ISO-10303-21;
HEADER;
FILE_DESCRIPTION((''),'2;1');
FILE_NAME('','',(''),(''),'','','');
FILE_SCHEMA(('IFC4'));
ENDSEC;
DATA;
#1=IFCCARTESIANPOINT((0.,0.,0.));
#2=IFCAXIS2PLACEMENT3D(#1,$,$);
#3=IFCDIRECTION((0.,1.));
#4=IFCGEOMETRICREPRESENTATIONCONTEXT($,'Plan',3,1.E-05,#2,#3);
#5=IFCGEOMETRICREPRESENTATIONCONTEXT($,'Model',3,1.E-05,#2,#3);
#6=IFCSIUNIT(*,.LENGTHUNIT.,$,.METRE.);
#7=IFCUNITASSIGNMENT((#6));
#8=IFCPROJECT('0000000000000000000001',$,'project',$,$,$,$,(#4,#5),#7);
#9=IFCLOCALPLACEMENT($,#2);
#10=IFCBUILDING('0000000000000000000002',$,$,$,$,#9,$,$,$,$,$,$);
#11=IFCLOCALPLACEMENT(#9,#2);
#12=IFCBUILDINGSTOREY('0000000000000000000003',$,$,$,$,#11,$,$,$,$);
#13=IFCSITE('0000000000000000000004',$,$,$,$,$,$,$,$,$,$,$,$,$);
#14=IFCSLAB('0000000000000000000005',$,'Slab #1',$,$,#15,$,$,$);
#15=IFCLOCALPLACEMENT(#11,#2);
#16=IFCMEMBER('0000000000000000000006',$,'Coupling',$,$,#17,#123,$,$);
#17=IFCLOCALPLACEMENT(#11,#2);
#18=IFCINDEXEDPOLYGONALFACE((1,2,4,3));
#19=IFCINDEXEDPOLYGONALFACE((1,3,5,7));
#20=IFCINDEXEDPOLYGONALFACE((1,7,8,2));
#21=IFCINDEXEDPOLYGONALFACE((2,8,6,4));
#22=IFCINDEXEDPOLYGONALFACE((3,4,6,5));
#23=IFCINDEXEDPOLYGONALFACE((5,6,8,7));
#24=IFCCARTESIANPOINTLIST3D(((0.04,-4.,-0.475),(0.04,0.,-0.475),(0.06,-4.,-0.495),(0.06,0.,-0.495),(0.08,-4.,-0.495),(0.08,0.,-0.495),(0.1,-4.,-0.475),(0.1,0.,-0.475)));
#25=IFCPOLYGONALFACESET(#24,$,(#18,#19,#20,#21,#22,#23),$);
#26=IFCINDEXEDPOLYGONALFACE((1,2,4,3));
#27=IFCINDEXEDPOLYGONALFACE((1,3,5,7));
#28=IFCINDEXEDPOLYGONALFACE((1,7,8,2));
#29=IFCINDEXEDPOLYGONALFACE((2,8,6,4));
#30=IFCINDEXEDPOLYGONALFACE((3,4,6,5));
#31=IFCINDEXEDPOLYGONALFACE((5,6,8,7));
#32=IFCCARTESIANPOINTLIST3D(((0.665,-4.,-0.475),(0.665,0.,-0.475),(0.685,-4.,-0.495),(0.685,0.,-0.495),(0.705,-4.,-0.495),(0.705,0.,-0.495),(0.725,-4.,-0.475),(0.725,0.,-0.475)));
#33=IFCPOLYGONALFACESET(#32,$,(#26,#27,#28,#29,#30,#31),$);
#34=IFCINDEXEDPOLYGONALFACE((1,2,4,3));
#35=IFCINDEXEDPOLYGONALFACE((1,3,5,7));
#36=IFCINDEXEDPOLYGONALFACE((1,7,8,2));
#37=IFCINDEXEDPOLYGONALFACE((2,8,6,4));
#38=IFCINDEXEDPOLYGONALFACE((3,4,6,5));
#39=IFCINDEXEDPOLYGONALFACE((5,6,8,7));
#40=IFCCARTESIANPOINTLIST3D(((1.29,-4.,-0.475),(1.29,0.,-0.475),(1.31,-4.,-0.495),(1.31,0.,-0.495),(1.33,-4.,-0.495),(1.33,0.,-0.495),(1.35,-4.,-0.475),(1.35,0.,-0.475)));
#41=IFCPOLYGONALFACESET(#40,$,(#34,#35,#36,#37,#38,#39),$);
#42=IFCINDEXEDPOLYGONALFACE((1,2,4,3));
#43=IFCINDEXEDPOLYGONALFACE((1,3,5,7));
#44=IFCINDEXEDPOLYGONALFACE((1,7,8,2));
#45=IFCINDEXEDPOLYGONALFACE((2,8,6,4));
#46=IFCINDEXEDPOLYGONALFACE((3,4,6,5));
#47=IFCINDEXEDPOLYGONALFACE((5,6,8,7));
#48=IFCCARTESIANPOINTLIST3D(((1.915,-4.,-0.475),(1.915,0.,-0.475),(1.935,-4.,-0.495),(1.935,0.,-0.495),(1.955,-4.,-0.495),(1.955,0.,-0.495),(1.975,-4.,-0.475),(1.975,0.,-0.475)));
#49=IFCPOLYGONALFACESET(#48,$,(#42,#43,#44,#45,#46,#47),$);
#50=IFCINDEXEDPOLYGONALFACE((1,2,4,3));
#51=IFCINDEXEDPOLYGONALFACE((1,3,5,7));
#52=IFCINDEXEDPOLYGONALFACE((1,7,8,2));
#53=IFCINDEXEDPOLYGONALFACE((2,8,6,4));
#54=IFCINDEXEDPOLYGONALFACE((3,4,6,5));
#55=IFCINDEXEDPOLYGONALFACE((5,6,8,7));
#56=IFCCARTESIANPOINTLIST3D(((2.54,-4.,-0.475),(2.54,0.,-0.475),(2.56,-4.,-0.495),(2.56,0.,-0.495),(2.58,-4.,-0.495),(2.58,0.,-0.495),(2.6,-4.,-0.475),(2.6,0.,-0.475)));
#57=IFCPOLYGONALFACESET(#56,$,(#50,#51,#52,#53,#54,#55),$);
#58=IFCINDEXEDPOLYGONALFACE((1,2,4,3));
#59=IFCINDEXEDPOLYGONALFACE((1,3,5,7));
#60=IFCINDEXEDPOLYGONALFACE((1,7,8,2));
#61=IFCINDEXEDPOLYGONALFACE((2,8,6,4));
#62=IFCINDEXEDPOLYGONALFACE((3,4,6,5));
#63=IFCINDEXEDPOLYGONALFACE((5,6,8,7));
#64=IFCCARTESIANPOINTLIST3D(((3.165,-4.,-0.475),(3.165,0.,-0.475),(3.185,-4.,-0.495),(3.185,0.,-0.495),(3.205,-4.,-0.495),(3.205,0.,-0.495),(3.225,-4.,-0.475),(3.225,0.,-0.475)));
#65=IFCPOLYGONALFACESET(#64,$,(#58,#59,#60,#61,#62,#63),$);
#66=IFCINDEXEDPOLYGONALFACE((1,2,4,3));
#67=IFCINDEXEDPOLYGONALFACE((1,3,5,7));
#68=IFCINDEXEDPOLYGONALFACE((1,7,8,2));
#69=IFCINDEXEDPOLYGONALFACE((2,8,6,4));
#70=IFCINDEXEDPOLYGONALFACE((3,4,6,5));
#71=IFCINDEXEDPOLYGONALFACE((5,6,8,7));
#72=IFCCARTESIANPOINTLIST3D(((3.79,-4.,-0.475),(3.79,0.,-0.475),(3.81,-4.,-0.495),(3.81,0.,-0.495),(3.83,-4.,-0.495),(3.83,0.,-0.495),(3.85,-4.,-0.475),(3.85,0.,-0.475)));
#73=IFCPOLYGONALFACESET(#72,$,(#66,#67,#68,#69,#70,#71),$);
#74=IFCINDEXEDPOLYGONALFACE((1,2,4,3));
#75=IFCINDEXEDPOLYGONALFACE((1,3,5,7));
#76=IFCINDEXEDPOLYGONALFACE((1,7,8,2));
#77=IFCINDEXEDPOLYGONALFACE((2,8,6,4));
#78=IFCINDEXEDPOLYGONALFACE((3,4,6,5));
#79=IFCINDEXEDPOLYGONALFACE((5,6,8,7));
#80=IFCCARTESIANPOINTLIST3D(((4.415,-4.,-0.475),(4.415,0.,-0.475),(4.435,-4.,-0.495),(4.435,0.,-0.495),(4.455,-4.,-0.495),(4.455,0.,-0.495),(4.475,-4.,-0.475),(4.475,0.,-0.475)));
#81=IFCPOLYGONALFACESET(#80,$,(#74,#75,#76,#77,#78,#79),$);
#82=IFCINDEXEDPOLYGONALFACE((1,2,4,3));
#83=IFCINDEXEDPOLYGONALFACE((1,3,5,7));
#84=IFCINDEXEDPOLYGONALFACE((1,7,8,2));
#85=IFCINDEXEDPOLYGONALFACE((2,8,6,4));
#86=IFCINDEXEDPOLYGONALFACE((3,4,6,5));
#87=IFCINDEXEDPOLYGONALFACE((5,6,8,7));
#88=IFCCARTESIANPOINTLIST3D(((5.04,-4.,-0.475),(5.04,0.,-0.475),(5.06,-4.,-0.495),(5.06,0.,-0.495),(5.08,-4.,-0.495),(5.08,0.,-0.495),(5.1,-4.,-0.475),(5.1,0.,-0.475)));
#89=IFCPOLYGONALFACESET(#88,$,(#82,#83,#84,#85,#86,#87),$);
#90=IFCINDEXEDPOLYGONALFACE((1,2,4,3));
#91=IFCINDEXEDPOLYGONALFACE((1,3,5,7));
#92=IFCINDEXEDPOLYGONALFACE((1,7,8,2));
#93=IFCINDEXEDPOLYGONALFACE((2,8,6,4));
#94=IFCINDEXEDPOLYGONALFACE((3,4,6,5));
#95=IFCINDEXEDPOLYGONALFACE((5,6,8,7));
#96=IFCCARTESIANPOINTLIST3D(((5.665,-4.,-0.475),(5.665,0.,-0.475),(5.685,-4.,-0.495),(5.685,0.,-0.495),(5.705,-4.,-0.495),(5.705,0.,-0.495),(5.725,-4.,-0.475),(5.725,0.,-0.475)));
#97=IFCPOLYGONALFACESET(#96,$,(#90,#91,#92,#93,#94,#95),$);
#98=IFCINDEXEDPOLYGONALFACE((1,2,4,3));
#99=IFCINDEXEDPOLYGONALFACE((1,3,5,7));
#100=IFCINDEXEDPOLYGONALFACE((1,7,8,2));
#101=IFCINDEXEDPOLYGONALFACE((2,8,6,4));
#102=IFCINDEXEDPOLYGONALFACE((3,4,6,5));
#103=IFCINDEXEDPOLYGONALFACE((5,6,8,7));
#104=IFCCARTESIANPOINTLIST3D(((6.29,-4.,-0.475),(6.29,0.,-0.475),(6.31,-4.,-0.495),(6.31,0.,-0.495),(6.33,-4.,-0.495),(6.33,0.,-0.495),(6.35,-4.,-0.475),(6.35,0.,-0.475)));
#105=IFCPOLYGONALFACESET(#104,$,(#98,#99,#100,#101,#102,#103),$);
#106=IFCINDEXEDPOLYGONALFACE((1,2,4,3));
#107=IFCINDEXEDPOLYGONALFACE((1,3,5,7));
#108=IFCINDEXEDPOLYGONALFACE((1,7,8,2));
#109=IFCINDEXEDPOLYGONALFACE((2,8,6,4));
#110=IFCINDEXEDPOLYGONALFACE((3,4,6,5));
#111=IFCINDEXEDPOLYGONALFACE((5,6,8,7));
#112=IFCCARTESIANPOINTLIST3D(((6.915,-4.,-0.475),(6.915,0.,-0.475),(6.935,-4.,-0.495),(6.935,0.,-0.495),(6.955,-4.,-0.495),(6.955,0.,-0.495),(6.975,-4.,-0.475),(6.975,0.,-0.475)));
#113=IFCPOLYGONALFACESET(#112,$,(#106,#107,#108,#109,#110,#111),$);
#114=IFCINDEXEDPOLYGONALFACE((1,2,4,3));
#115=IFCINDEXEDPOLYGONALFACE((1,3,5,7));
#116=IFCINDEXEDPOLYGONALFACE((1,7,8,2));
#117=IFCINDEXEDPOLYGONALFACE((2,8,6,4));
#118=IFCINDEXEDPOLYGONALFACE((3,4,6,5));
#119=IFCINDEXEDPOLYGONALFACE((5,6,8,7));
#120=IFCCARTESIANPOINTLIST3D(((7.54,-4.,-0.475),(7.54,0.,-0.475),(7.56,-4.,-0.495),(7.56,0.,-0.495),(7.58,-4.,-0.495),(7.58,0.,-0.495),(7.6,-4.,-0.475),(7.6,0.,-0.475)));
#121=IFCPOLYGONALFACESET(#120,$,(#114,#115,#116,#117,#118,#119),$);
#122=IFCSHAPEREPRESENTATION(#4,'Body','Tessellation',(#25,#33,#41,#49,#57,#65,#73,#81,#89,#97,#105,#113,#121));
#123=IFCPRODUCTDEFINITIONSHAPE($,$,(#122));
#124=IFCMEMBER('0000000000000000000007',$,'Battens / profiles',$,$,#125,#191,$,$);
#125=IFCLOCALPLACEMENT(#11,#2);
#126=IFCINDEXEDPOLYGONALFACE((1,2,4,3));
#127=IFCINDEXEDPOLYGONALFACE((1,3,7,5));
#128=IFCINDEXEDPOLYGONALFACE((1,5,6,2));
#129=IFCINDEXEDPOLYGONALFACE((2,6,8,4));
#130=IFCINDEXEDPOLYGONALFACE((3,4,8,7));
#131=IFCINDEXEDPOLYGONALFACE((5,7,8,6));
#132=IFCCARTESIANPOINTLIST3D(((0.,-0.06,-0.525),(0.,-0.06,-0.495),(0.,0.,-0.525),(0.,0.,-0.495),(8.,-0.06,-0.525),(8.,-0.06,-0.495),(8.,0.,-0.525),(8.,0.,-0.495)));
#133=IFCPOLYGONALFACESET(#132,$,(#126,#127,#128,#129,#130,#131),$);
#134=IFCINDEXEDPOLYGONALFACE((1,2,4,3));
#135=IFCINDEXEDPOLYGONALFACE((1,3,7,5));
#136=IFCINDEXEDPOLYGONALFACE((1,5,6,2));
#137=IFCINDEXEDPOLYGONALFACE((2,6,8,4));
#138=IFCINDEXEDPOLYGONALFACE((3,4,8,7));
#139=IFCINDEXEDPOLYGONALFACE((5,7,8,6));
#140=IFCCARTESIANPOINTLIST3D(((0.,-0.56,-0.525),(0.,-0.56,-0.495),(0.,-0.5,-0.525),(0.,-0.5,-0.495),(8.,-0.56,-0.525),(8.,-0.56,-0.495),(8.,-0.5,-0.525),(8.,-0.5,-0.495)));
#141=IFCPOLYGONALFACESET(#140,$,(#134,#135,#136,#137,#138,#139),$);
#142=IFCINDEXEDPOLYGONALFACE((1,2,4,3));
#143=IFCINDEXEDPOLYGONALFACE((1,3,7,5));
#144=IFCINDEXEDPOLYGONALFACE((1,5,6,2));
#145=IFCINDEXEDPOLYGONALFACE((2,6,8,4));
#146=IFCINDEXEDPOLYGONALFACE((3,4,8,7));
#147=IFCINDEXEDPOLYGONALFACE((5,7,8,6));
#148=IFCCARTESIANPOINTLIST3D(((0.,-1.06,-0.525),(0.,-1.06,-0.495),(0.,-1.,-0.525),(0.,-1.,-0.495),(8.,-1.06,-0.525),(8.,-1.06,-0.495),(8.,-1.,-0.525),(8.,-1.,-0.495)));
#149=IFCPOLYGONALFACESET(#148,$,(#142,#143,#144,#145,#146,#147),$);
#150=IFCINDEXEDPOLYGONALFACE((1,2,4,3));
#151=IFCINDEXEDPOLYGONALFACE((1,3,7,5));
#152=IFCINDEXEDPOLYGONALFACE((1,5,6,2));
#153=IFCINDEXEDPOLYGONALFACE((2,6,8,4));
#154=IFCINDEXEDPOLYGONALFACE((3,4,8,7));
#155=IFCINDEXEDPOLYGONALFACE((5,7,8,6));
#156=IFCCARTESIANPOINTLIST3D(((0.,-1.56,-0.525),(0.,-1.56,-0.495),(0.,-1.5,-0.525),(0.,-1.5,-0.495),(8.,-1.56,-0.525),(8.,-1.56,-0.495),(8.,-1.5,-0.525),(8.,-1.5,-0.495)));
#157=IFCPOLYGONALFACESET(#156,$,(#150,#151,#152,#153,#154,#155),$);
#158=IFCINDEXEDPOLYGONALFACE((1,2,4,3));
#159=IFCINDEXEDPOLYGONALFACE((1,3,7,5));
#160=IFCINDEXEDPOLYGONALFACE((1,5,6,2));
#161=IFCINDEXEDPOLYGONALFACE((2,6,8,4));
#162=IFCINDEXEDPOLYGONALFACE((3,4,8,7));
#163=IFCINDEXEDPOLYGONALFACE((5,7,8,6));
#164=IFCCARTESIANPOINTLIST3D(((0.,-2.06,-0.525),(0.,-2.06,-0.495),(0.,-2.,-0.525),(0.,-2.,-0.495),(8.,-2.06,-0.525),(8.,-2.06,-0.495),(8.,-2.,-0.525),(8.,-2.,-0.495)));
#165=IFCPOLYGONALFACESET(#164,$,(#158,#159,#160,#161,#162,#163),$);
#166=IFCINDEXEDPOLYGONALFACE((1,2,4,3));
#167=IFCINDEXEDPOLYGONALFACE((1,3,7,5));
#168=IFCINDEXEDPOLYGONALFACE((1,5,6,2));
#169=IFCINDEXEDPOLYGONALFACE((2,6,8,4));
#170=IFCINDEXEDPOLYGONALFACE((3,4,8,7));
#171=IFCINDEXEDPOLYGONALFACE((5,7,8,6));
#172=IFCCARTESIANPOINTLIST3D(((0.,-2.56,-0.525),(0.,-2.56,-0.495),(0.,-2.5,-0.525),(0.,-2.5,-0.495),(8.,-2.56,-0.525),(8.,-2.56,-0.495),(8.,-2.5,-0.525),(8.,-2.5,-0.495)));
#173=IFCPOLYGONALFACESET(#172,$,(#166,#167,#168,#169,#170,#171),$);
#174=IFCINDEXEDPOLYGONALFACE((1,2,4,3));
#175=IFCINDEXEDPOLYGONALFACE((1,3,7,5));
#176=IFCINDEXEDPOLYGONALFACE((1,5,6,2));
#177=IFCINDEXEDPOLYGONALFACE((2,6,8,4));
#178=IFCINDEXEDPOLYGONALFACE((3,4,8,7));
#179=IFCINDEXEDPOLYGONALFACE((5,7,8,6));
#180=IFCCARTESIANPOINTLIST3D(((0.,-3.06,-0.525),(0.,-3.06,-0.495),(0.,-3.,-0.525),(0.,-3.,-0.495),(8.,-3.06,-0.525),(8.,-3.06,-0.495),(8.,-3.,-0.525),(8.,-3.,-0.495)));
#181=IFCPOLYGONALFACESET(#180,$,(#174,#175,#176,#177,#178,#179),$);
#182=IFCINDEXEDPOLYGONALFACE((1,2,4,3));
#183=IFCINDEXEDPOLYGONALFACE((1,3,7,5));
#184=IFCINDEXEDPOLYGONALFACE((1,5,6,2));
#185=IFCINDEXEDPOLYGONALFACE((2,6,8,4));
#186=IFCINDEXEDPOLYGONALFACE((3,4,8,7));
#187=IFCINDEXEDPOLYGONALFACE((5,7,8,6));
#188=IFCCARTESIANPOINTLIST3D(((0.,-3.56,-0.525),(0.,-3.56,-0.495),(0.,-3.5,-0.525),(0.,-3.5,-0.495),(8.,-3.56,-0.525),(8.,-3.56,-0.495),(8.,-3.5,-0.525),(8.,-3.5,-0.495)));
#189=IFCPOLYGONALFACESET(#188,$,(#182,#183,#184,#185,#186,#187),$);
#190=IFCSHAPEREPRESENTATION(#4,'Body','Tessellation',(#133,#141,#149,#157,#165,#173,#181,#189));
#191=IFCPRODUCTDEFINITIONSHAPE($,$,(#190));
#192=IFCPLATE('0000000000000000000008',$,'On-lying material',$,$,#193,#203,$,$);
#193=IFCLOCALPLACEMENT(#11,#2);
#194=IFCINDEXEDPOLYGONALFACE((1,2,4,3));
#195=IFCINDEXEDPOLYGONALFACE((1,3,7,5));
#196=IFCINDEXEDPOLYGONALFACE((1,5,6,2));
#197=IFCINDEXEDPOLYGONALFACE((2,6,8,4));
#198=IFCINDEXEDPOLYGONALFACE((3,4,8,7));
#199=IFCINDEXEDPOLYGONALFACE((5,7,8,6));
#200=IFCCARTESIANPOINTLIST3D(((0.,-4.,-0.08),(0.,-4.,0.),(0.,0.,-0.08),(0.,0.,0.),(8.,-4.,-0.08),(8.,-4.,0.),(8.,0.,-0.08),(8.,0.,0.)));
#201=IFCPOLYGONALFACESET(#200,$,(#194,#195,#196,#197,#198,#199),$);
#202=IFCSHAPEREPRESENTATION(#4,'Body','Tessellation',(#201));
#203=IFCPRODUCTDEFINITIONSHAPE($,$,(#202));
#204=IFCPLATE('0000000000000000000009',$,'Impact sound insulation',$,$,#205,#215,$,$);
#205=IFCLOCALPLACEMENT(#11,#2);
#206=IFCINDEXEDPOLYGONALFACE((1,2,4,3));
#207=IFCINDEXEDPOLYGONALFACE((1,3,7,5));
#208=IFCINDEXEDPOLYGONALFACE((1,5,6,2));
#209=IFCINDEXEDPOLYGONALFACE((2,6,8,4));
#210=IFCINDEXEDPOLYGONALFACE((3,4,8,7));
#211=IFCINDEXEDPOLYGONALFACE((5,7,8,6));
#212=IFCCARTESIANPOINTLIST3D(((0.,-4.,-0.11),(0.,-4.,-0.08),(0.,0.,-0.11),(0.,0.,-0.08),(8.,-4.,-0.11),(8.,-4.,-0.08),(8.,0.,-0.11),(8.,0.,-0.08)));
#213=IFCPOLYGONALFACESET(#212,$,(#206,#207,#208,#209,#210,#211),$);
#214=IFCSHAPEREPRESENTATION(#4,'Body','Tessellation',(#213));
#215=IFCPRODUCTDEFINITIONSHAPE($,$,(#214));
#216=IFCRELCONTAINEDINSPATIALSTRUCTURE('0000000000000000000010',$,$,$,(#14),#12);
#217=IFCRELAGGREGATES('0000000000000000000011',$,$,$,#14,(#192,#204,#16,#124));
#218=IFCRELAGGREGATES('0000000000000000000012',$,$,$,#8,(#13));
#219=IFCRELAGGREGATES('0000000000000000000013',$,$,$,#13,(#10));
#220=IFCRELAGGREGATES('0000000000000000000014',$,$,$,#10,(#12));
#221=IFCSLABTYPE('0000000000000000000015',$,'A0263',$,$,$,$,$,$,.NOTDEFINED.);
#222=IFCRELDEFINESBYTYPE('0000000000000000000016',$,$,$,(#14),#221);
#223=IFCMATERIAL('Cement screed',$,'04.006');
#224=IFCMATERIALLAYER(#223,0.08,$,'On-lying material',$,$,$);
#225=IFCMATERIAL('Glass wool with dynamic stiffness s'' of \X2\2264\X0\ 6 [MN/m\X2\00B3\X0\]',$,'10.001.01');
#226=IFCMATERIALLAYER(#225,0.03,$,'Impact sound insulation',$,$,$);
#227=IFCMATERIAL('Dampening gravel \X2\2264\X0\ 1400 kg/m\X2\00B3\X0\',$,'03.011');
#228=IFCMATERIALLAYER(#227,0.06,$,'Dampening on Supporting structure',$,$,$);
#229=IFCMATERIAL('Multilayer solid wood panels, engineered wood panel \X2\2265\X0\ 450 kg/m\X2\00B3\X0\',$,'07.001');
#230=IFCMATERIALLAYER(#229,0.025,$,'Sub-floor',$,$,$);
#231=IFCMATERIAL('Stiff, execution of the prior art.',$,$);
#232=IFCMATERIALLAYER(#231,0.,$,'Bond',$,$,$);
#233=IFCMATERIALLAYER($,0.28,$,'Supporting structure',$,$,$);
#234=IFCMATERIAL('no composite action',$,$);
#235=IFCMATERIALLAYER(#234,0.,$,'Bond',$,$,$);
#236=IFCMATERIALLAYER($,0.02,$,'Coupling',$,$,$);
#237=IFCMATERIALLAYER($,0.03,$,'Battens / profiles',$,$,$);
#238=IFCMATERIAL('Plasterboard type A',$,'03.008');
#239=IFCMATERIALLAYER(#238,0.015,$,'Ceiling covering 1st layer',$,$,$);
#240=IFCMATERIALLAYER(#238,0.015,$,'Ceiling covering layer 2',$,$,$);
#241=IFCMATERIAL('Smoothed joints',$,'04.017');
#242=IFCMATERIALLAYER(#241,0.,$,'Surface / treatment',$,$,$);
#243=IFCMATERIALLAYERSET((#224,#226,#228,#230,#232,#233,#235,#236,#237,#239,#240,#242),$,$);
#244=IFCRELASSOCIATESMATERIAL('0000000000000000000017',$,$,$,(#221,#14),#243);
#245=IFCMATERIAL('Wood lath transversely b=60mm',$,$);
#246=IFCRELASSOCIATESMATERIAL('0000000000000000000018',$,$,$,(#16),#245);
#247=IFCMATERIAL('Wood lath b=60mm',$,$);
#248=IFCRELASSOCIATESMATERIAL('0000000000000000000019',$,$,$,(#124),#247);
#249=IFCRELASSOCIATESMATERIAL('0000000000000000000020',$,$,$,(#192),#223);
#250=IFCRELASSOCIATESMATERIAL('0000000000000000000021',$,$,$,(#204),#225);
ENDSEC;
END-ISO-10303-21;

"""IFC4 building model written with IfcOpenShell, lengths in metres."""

from ifc_helpers import new_model, si_unit, direction, frame, frame_2d, origin, origin_with_axes, place, context, project, spatial, polyline, rectangle, outline, extrude, material, layer, layer_set, type_object, element, aggregate, save


model = new_model("IFC4")

# Units and contexts
plan_context = context("Plan", 3, precision=1e-05, world=origin(), true_north=direction((0.0, 1.0)))
model_context = context("Model", 3, precision=1e-05, world=origin(), true_north=direction((0.0, 1.0)))
ifc_project = project(units=[si_unit("LENGTHUNIT", "METRE")], contexts=[plan_context, model_context])

# Site, building, storey
site = spatial("IfcSite", under=ifc_project)
building_placement = place(None, origin())
building = spatial("IfcBuilding", under=site, at=building_placement)
storey_placement = place(building_placement, origin())
storey = spatial("IfcBuildingStorey", under=building, at=storey_placement)

# Slab, members, plates
ifc_material_1 = material(Name="Cement screed", Category="04.006")
ifc_layer_1 = layer(ifc_material_1, 0.08, Name="On-lying material")
ifc_material_2 = material(Name="Glass wool with dynamic stiffness s' of ≤ 6 [MN/m³]", Category="10.001.01")
ifc_layer_2 = layer(ifc_material_2, 0.03, Name="Impact sound insulation")
ifc_material_3 = material(Name="Dampening gravel ≤ 1400 kg/m³", Category="03.011")
ifc_layer_3 = layer(ifc_material_3, 0.06, Name="Dampening on Supporting structure")
ifc_material_4 = material(Name="Multilayer solid wood panels, engineered wood panel ≥ 450 kg/m³", Category="07.001")
ifc_layer_4 = layer(ifc_material_4, 0.025, Name="Sub-floor")
ifc_material_5 = material(Name="Stiff, execution of the prior art.")
ifc_layer_5 = layer(ifc_material_5, 0.0, Name="Bond")
ifc_layer_6 = layer(None, 0.28, Name="Supporting structure")
ifc_material_6 = material(Name="no composite action")
ifc_layer_7 = layer(ifc_material_6, 0.0, Name="Bond")
ifc_layer_8 = layer(None, 0.02, Name="Coupling")
ifc_layer_9 = layer(None, 0.03, Name="Battens / profiles")
ifc_material_7 = material(Name="Plasterboard type A", Category="03.008")
ifc_layer_10 = layer(ifc_material_7, 0.015, Name="Ceiling covering 1st layer")
ifc_layer_11 = layer(ifc_material_7, 0.015, Name="Ceiling covering layer 2")
ifc_material_8 = material(Name="Smoothed joints", Category="04.017")
ifc_layer_12 = layer(ifc_material_8, 0.0, Name="Surface / treatment")
ifc_layer_set = layer_set([ifc_layer_1, ifc_layer_2, ifc_layer_3, ifc_layer_4, ifc_layer_5, ifc_layer_6, ifc_layer_7, ifc_layer_8, ifc_layer_9, ifc_layer_10, ifc_layer_11, ifc_layer_12])
slab_type = type_object("IfcSlabType", Name="A0263", PredefinedType="NOTDEFINED", material=ifc_layer_set)
slab_placement = place(None, frame((0.0, 0.0, 0.0), z_axis=(0.0, 0.0, -1.0), x_axis=(1.0, 0.0, 0.0)))
slab = element("IfcSlab", 1, at=slab_placement, inside=storey, type_object=slab_type, material=ifc_layer_set, Name="Slab #1")
ifc_material_9 = material(Name="Wood lath transversely b=60mm")
member_1_placement = place(slab_placement, origin())
member_1 = element("IfcMember", 2, at=member_1_placement, material=ifc_material_9, Name="Coupling", context=plan_context, shape_type="SweptSolid", body=[
    extrude(outline(polyline([(0.0, 0.0), (0.06, 0.0), (0.04, 0.02), (0.02, 0.02), (0.0, 0.0)])), frame((0.04, 4.0, 0.475), z_axis=(0.0, -1.0, 0.0), x_axis=(1.0, 0.0, 0.0)), (0.0, 0.0, 1.0), 4.0),
    extrude(outline(polyline([(0.0, 0.0), (0.06, 0.0), (0.04, 0.02), (0.02, 0.02), (0.0, 0.0)])), frame((0.665, 4.0, 0.475), z_axis=(0.0, -1.0, 0.0), x_axis=(1.0, 0.0, 0.0)), (0.0, 0.0, 1.0), 4.0),
    extrude(outline(polyline([(0.0, 0.0), (0.06, 0.0), (0.04, 0.02), (0.02, 0.02), (0.0, 0.0)])), frame((1.29, 4.0, 0.475), z_axis=(0.0, -1.0, 0.0), x_axis=(1.0, 0.0, 0.0)), (0.0, 0.0, 1.0), 4.0),
    extrude(outline(polyline([(0.0, 0.0), (0.06, 0.0), (0.04, 0.02), (0.02, 0.02), (0.0, 0.0)])), frame((1.915, 4.0, 0.475), z_axis=(0.0, -1.0, 0.0), x_axis=(1.0, 0.0, 0.0)), (0.0, 0.0, 1.0), 4.0),
    extrude(outline(polyline([(0.0, 0.0), (0.06, 0.0), (0.04, 0.02), (0.02, 0.02), (0.0, 0.0)])), frame((2.54, 4.0, 0.475), z_axis=(0.0, -1.0, 0.0), x_axis=(1.0, 0.0, 0.0)), (0.0, 0.0, 1.0), 4.0),
    extrude(outline(polyline([(0.0, 0.0), (0.06, 0.0), (0.04, 0.02), (0.02, 0.02), (0.0, 0.0)])), frame((3.165, 4.0, 0.475), z_axis=(0.0, -1.0, 0.0), x_axis=(1.0, 0.0, 0.0)), (0.0, 0.0, 1.0), 4.0),
    extrude(outline(polyline([(0.0, 0.0), (0.06, 0.0), (0.04, 0.02), (0.02, 0.02), (0.0, 0.0)])), frame((3.79, 4.0, 0.475), z_axis=(0.0, -1.0, 0.0), x_axis=(1.0, 0.0, 0.0)), (0.0, 0.0, 1.0), 4.0),
    extrude(outline(polyline([(0.0, 0.0), (0.06, 0.0), (0.04, 0.02), (0.02, 0.02), (0.0, 0.0)])), frame((4.415, 4.0, 0.475), z_axis=(0.0, -1.0, 0.0), x_axis=(1.0, 0.0, 0.0)), (0.0, 0.0, 1.0), 4.0),
    extrude(outline(polyline([(0.0, 0.0), (0.06, 0.0), (0.04, 0.02), (0.02, 0.02), (0.0, 0.0)])), frame((5.04, 4.0, 0.475), z_axis=(0.0, -1.0, 0.0), x_axis=(1.0, 0.0, 0.0)), (0.0, 0.0, 1.0), 4.0),
    extrude(outline(polyline([(0.0, 0.0), (0.06, 0.0), (0.04, 0.02), (0.02, 0.02), (0.0, 0.0)])), frame((5.665, 4.0, 0.475), z_axis=(0.0, -1.0, 0.0), x_axis=(1.0, 0.0, 0.0)), (0.0, 0.0, 1.0), 4.0),
    extrude(outline(polyline([(0.0, 0.0), (0.06, 0.0), (0.04, 0.02), (0.02, 0.02), (0.0, 0.0)])), frame((6.29, 4.0, 0.475), z_axis=(0.0, -1.0, 0.0), x_axis=(1.0, 0.0, 0.0)), (0.0, 0.0, 1.0), 4.0),
    extrude(outline(polyline([(0.0, 0.0), (0.06, 0.0), (0.04, 0.02), (0.02, 0.02), (0.0, 0.0)])), frame((6.915, 4.0, 0.475), z_axis=(0.0, -1.0, 0.0), x_axis=(1.0, 0.0, 0.0)), (0.0, 0.0, 1.0), 4.0),
    extrude(outline(polyline([(0.0, 0.0), (0.06, 0.0), (0.04, 0.02), (0.02, 0.02), (0.0, 0.0)])), frame((7.54, 4.0, 0.475), z_axis=(0.0, -1.0, 0.0), x_axis=(1.0, 0.0, 0.0)), (0.0, 0.0, 1.0), 4.0),
])
ifc_material_10 = material(Name="Wood lath b=60mm")
member_2_placement = place(slab_placement, origin())
member_2 = element("IfcMember", 3, at=member_2_placement, material=ifc_material_10, Name="Battens / profiles", context=plan_context, shape_type="SweptSolid", body=[
    extrude(rectangle(XDim=0.06, YDim=0.03, at=frame_2d((0.03, 0.015), x_axis=(1.0, 0.0))), frame((0.0, 0.0, 0.495), z_axis=(1.0, 0.0, 0.0), x_axis=(0.0, 1.0, 0.0)), (0.0, 0.0, 1.0), 8.0),
    extrude(rectangle(XDim=0.06, YDim=0.03, at=frame_2d((0.03, 0.015), x_axis=(1.0, 0.0))), frame((0.0, 0.5, 0.495), z_axis=(1.0, 0.0, 0.0), x_axis=(0.0, 1.0, 0.0)), (0.0, 0.0, 1.0), 8.0),
    extrude(rectangle(XDim=0.06, YDim=0.03, at=frame_2d((0.03, 0.015), x_axis=(1.0, 0.0))), frame((0.0, 1.0, 0.495), z_axis=(1.0, 0.0, 0.0), x_axis=(0.0, 1.0, 0.0)), (0.0, 0.0, 1.0), 8.0),
    extrude(rectangle(XDim=0.06, YDim=0.03, at=frame_2d((0.03, 0.015), x_axis=(1.0, 0.0))), frame((0.0, 1.5, 0.495), z_axis=(1.0, 0.0, 0.0), x_axis=(0.0, 1.0, 0.0)), (0.0, 0.0, 1.0), 8.0),
    extrude(rectangle(XDim=0.06, YDim=0.03, at=frame_2d((0.03, 0.015), x_axis=(1.0, 0.0))), frame((0.0, 2.0, 0.495), z_axis=(1.0, 0.0, 0.0), x_axis=(0.0, 1.0, 0.0)), (0.0, 0.0, 1.0), 8.0),
    extrude(rectangle(XDim=0.06, YDim=0.03, at=frame_2d((0.03, 0.015), x_axis=(1.0, 0.0))), frame((0.0, 2.5, 0.495), z_axis=(1.0, 0.0, 0.0), x_axis=(0.0, 1.0, 0.0)), (0.0, 0.0, 1.0), 8.0),
    extrude(rectangle(XDim=0.06, YDim=0.03, at=frame_2d((0.03, 0.015), x_axis=(1.0, 0.0))), frame((0.0, 3.0, 0.495), z_axis=(1.0, 0.0, 0.0), x_axis=(0.0, 1.0, 0.0)), (0.0, 0.0, 1.0), 8.0),
    extrude(rectangle(XDim=0.06, YDim=0.03, at=frame_2d((0.03, 0.015), x_axis=(1.0, 0.0))), frame((0.0, 3.5, 0.495), z_axis=(1.0, 0.0, 0.0), x_axis=(0.0, 1.0, 0.0)), (0.0, 0.0, 1.0), 8.0),
])
plate_1_placement = place(slab_placement, origin())
plate_1 = element("IfcPlate", 4, at=plate_1_placement, material=ifc_material_1, Name="On-lying material", context=plan_context, shape_type="SweptSolid", body=[
    extrude(rectangle(XDim=8.0, YDim=4.0, at=frame_2d((4.0, 2.0), x_axis=(1.0, 0.0))), origin_with_axes(), (0.0, 0.0, 1.0), 0.08),
])
plate_2_placement = place(slab_placement, origin())
plate_2 = element("IfcPlate", 5, at=plate_2_placement, material=ifc_material_2, Name="Impact sound insulation", context=plan_context, shape_type="SweptSolid", body=[
    extrude(rectangle(XDim=8.0, YDim=4.0, at=frame_2d((4.0, 2.0), x_axis=(1.0, 0.0))), frame((0.0, 0.0, 0.08), z_axis=(0.0, 0.0, 1.0), x_axis=(1.0, 0.0, 0.0)), (0.0, 0.0, 1.0), 0.03),
])
aggregate(slab, [plate_1, plate_2, member_1, member_2])

save(model, "model.ifc")
